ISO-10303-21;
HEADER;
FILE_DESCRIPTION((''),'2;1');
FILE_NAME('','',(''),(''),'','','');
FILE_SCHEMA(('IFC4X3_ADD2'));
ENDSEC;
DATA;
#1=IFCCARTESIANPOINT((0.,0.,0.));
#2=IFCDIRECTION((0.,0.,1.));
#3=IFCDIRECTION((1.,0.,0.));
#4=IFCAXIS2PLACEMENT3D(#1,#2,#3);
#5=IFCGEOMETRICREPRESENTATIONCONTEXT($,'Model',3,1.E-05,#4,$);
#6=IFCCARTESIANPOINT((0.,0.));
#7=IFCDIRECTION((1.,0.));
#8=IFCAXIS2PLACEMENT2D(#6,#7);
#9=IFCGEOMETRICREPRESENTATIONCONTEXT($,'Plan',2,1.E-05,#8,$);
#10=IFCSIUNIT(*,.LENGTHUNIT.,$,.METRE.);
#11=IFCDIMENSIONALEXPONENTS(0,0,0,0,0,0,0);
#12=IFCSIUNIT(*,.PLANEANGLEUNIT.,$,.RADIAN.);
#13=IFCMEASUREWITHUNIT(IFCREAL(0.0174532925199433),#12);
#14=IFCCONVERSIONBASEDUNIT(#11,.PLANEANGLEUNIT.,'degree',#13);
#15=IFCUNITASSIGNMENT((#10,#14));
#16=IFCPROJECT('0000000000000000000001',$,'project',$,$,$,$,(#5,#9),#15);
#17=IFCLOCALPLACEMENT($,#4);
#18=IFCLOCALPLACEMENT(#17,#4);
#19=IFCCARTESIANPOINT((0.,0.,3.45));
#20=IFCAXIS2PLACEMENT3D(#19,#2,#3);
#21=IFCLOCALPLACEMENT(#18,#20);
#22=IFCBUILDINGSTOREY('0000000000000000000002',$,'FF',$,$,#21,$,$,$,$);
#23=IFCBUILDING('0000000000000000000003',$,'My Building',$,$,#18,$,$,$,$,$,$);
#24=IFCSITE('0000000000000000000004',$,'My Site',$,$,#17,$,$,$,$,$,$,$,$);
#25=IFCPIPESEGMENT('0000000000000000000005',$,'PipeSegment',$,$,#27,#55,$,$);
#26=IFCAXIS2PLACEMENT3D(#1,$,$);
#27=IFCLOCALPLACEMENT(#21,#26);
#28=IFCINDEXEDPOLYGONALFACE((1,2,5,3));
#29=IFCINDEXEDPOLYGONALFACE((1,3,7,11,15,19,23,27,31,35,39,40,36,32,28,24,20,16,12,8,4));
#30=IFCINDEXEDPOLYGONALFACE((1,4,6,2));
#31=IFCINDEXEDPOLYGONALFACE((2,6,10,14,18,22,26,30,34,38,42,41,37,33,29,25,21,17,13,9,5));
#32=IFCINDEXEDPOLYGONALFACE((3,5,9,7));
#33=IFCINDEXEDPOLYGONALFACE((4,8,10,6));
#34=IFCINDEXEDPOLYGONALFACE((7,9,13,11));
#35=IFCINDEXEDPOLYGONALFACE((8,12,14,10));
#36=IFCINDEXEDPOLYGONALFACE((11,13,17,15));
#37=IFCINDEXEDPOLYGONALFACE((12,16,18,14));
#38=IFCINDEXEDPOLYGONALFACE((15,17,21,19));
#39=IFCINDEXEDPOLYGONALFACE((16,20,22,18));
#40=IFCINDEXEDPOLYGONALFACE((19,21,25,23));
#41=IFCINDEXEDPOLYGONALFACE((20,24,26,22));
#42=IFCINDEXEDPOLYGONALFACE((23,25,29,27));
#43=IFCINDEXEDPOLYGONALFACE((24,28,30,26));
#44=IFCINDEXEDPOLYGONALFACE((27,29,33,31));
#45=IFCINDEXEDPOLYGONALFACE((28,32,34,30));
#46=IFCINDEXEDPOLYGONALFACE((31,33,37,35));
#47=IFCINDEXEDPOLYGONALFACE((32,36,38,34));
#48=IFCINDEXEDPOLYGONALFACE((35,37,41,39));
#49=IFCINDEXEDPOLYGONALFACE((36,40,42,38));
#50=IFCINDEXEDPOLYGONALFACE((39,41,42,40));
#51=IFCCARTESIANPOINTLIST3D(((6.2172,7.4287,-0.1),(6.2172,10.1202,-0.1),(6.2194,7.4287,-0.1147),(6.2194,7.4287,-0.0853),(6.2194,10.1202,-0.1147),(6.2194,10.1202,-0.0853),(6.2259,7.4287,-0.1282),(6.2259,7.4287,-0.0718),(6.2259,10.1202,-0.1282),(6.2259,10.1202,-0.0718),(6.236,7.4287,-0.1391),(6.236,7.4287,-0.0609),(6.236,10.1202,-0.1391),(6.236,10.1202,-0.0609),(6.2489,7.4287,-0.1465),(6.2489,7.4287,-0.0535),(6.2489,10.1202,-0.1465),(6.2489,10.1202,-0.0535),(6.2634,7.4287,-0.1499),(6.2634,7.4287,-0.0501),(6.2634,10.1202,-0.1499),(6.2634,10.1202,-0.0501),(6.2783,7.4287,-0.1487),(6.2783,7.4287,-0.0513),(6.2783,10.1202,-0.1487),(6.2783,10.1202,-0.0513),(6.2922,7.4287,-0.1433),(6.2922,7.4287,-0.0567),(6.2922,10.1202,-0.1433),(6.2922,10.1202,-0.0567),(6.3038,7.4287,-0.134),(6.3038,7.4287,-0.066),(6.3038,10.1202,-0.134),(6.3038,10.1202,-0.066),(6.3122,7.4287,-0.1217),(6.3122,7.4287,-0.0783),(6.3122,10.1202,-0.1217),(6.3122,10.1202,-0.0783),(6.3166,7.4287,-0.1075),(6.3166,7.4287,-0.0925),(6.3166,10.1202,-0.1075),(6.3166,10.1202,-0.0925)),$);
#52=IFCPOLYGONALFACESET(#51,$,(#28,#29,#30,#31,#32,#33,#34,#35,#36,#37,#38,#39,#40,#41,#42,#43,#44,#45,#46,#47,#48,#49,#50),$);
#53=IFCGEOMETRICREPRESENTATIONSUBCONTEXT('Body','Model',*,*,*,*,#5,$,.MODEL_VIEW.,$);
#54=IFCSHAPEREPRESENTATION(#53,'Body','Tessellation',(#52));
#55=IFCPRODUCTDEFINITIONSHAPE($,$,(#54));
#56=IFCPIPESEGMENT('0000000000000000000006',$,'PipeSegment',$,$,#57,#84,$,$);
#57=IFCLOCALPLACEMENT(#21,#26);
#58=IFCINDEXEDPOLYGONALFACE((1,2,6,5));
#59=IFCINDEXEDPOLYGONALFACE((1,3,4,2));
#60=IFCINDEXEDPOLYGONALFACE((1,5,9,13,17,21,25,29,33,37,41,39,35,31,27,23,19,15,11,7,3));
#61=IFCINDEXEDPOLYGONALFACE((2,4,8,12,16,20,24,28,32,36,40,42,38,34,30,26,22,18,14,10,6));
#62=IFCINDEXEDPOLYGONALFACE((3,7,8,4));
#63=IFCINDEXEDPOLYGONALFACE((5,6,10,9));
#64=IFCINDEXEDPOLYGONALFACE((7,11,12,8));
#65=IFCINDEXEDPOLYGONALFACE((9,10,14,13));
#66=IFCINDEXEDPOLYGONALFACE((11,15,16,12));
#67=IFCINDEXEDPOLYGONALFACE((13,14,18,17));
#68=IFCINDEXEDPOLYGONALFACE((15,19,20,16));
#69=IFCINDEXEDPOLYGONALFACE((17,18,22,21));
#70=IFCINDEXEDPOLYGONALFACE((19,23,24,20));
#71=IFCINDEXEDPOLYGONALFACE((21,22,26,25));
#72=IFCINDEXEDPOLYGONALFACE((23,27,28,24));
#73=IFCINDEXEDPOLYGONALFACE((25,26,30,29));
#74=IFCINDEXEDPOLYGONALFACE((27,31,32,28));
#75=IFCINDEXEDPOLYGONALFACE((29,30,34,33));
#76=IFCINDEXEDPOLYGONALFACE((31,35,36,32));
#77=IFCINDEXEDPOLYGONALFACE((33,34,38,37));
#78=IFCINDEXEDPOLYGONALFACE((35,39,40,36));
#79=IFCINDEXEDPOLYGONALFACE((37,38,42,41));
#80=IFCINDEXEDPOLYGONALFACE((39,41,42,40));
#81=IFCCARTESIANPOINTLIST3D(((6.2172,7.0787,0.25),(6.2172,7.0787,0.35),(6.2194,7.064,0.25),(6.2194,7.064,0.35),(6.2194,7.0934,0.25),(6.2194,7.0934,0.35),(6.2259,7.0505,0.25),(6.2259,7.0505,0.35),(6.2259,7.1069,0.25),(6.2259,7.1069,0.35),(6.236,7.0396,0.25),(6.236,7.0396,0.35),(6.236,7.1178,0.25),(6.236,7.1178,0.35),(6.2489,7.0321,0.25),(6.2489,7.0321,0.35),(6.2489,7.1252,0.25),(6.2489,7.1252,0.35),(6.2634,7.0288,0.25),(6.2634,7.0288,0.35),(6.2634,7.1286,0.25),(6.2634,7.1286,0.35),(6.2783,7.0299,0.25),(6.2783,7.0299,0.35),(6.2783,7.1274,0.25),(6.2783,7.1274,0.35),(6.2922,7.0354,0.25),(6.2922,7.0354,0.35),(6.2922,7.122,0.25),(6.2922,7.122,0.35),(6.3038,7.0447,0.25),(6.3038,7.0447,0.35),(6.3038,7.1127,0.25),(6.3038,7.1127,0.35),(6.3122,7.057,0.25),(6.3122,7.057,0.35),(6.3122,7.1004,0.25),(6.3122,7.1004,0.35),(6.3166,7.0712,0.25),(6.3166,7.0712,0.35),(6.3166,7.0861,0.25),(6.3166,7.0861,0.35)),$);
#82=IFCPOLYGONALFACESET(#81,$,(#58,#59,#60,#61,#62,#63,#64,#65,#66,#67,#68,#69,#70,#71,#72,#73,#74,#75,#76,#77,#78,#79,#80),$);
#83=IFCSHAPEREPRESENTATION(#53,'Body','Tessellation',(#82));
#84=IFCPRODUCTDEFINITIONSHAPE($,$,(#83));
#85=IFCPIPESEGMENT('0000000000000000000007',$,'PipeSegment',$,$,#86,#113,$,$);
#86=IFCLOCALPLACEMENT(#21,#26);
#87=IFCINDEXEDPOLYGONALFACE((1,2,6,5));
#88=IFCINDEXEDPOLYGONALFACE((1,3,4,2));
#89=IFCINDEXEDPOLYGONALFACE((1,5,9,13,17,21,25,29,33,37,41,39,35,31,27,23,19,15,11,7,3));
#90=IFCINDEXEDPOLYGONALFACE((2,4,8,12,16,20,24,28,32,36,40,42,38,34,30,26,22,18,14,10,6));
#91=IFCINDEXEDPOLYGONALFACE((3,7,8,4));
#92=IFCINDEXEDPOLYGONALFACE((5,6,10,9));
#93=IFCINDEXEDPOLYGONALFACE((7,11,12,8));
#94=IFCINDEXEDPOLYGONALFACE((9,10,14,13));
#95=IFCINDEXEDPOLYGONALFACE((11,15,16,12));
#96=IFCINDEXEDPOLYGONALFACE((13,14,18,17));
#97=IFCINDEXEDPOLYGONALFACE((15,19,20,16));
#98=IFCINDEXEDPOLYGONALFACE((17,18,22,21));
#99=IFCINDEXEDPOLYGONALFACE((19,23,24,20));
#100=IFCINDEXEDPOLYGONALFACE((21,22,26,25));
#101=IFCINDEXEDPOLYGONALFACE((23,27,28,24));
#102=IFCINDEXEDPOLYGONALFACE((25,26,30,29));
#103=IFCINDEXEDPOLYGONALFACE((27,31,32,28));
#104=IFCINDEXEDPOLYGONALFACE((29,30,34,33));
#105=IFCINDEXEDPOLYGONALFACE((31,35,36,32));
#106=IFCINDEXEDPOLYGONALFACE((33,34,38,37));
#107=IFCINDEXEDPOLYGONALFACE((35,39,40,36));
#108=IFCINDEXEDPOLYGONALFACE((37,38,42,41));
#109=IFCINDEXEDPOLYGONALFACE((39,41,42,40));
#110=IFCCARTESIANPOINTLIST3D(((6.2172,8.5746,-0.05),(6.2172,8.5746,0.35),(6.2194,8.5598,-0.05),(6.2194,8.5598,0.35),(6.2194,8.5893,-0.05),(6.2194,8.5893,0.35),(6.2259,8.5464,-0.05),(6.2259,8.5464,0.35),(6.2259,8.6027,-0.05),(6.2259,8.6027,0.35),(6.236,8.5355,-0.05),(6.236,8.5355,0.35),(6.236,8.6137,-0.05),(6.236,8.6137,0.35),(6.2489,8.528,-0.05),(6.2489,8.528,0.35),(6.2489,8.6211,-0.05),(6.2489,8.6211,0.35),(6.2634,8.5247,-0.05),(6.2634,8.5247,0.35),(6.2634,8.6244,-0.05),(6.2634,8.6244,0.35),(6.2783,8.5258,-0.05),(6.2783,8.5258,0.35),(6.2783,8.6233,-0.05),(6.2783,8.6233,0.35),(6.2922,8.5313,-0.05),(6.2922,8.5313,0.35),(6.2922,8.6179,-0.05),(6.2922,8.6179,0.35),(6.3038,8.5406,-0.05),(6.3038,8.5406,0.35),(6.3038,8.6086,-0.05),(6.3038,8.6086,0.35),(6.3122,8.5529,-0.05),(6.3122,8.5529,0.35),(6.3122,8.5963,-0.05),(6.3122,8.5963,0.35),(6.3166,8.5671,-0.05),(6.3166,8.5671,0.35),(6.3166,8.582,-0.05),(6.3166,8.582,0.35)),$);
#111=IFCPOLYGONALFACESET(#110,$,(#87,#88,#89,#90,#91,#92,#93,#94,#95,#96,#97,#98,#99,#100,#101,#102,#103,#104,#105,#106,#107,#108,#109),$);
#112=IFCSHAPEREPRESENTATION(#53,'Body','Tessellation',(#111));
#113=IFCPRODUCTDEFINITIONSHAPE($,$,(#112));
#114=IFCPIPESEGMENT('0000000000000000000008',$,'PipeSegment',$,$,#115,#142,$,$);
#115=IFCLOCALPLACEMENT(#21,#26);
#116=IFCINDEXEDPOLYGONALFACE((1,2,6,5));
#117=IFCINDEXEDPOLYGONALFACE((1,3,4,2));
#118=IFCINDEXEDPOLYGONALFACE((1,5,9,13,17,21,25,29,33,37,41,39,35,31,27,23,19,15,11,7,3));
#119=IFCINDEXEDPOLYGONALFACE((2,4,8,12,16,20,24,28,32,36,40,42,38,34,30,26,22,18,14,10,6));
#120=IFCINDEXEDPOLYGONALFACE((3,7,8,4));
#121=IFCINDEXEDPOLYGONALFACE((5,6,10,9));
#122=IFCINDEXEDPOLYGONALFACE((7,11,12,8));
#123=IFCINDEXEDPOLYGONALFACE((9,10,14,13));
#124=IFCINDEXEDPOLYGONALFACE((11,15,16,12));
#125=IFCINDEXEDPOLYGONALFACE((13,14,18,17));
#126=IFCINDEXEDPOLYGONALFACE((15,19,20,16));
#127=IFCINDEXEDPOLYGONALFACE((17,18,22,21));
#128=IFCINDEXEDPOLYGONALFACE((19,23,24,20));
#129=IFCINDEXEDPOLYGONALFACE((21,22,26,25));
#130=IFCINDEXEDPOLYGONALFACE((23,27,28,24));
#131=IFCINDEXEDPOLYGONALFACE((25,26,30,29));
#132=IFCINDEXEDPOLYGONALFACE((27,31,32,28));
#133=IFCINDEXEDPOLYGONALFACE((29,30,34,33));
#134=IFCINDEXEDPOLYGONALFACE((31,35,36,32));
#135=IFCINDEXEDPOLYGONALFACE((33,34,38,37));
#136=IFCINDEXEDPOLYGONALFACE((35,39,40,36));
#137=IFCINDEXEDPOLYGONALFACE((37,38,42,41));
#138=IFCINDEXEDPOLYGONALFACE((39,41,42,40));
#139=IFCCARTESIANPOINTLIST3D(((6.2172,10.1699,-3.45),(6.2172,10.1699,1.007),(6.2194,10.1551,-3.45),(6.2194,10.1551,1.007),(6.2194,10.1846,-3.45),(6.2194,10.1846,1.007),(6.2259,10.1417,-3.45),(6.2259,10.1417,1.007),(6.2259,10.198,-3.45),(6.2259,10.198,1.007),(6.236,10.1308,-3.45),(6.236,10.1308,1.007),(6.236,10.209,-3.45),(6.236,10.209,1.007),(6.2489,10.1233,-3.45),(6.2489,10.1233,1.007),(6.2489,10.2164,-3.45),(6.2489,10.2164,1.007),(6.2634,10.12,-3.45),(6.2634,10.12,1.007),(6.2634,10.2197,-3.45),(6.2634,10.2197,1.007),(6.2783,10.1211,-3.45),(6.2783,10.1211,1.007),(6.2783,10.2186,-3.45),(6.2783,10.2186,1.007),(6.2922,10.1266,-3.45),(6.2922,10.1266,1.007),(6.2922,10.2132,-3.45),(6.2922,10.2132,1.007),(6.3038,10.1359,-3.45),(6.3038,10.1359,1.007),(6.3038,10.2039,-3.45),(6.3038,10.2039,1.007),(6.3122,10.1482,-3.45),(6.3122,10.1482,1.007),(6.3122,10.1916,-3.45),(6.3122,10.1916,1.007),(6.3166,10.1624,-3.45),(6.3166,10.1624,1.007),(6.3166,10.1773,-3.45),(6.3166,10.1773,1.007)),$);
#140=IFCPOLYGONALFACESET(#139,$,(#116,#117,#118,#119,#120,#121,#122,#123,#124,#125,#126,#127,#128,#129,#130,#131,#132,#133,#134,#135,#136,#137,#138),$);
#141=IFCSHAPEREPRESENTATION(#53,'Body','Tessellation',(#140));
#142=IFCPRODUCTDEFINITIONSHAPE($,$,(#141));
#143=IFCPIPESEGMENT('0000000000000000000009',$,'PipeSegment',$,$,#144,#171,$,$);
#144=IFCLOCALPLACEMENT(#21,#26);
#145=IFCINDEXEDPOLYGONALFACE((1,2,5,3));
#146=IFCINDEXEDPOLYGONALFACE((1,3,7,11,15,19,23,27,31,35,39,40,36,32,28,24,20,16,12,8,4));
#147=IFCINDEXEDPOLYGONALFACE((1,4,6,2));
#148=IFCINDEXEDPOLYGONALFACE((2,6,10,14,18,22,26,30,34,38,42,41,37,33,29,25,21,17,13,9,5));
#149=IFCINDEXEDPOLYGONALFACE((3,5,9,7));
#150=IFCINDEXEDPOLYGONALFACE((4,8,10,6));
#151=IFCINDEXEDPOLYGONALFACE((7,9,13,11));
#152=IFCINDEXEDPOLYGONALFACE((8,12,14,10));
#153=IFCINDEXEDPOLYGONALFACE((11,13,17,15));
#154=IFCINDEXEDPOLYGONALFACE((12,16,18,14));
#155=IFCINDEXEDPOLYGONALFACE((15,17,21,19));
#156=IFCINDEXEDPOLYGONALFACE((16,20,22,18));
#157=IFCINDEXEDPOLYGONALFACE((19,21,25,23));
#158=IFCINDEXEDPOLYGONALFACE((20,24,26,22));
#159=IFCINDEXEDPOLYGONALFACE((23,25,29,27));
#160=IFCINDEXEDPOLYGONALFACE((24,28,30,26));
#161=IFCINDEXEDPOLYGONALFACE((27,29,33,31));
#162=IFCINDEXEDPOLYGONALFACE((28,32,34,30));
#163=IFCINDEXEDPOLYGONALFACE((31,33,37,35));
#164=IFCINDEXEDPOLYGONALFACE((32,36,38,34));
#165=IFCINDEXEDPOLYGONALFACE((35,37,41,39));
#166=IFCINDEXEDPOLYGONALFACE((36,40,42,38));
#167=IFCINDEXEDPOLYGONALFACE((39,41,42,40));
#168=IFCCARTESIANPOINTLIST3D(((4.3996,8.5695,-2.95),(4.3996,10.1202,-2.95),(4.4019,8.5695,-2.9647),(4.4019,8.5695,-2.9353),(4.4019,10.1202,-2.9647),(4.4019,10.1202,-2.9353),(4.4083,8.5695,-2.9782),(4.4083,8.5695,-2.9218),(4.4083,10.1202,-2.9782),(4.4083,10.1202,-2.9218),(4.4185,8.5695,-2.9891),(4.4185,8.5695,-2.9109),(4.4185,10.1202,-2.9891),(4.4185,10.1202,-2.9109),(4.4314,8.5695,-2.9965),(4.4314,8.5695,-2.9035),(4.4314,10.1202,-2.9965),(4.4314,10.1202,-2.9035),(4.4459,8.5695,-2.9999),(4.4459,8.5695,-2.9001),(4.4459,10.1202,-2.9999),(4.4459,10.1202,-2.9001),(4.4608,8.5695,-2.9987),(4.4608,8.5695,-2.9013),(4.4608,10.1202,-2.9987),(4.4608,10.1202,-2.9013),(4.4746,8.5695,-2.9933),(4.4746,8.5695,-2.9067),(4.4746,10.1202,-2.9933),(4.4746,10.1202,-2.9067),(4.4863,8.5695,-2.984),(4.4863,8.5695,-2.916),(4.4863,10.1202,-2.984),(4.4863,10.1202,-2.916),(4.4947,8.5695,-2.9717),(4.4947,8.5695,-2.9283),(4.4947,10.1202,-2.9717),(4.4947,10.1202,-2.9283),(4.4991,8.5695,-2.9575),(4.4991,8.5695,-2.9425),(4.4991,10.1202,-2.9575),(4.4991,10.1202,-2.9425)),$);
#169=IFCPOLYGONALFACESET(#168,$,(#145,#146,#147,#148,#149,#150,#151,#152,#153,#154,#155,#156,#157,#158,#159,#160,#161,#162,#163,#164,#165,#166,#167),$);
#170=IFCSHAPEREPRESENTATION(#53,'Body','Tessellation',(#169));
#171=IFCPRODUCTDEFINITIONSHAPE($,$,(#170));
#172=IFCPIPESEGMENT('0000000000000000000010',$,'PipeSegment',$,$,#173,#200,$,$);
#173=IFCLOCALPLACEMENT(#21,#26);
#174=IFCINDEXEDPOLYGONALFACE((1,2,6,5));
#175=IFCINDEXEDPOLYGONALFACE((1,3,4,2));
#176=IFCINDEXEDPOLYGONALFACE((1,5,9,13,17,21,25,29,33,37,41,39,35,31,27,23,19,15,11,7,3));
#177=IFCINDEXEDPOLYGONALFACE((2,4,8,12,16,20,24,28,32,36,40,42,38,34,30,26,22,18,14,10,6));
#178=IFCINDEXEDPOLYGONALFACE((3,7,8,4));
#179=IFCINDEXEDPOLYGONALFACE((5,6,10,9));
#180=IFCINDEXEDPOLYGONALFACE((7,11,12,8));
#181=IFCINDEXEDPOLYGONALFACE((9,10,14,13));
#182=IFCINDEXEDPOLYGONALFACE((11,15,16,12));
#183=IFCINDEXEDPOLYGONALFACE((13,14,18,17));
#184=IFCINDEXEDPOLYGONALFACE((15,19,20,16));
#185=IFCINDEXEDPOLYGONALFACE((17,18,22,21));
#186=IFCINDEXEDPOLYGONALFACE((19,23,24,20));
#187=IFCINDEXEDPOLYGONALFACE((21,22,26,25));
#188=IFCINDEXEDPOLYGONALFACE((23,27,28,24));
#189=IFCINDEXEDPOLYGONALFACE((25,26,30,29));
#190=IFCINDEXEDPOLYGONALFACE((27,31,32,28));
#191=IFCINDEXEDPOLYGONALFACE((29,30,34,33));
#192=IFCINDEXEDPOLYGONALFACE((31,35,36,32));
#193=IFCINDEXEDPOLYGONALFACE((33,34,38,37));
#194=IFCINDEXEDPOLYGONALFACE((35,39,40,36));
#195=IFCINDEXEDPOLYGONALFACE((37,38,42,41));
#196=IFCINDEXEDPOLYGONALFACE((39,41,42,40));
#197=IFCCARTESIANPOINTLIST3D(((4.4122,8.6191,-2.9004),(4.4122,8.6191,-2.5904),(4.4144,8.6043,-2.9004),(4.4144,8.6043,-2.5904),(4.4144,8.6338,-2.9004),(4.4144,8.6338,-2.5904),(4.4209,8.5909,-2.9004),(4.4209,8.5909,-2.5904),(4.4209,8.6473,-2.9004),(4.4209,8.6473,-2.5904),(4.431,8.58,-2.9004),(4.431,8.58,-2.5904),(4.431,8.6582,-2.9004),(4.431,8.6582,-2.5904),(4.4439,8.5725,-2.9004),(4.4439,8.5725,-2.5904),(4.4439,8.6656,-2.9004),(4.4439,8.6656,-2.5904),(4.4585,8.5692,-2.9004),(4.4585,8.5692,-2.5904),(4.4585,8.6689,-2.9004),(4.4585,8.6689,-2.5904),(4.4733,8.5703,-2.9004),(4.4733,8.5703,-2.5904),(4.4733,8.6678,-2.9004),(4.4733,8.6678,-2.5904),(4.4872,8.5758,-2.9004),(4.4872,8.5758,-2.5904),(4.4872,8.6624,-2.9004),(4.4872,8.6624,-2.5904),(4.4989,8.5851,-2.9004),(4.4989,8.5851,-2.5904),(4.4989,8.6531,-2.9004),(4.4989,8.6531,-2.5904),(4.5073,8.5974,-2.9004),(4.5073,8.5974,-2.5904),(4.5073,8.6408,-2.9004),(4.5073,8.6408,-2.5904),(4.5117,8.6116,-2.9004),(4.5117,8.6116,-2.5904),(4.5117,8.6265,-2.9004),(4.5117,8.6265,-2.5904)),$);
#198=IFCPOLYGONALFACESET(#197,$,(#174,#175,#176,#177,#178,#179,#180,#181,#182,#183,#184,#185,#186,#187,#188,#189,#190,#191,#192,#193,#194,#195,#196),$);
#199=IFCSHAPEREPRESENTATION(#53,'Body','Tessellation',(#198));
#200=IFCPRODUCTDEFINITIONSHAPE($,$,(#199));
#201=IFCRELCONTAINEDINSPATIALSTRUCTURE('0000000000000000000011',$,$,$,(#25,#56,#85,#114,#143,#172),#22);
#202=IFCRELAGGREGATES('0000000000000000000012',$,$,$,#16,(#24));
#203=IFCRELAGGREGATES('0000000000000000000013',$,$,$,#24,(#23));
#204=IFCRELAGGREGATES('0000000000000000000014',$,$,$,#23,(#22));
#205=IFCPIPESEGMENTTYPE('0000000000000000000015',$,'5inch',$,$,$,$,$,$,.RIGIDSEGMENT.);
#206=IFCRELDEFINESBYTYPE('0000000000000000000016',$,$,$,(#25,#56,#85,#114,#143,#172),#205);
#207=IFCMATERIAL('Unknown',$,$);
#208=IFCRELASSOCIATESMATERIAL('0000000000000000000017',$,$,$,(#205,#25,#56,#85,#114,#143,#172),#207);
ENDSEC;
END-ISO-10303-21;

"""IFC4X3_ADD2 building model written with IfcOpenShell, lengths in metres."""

from ifc_helpers import new_model, entity, si_unit, converted_unit, frame, origin_with_axes, origin_2d_with_axis, place, context, subcontext, project, spatial, circle, extrude, material, material_profile, profile_set, profile_usage, type_object, element, save


model = new_model("IFC4X3_ADD2")

# Units and contexts
model_context = context("Model", 3, precision=1e-05, world=origin_with_axes())
plan_context = context("Plan", 2, precision=1e-05, world=origin_2d_with_axis())
body_context = subcontext(model_context, "Body", "Model", "MODEL_VIEW")
ifc_project = project(units=[si_unit("LENGTHUNIT", "METRE"), converted_unit("PLANEANGLEUNIT", "degree", entity("IfcReal", 0.0174532925199433), si_unit("PLANEANGLEUNIT", "RADIAN"), dimensions=[0, 0, 0, 0, 0, 0, 0])], contexts=[model_context, plan_context])

# Site, building, storey
site_placement = place(None, origin_with_axes())
site = spatial("IfcSite", under=ifc_project, at=site_placement, Name="My Site")
building_placement = place(site_placement, origin_with_axes())
building = spatial("IfcBuilding", under=site, at=building_placement, Name="My Building")
storey_placement = place(building_placement, frame((0.0, 0.0, 3.45), z_axis=(0.0, 0.0, 1.0), x_axis=(1.0, 0.0, 0.0)))
storey = spatial("IfcBuildingStorey", under=building, at=storey_placement, Name="FF")

# Shared definitions
ifc_material_1 = material(Name="Unknown")

# Pipe segments
ifc_material_profile_1 = material_profile(ifc_material_1, circle(Radius=0.05))
ifc_profile_set_1 = profile_set([ifc_material_profile_1])
ifc_profile_usage_1 = profile_usage(ifc_profile_set_1, cardinal=5)
pipe_segment_type_1 = type_object("IfcPipeSegmentType", Name="5inch", PredefinedType="RIGIDSEGMENT", material=ifc_profile_set_1)
pipe_segment_1_placement = place(storey_placement, frame((6.2672, 7.4287, -0.1), z_axis=(0.0, 1.0, 0.0), x_axis=(-1.0, 0.0, 0.0)))
element("IfcPipeSegment", 1, at=pipe_segment_1_placement, inside=storey, type_object=pipe_segment_type_1, material=ifc_profile_usage_1, Name="PipeSegment", context=body_context, shape_type="SweptSolid", body=[
    extrude(circle(Radius=0.05), origin_with_axes(), (0.0, 0.0, 1.0), 2.6915),
])
ifc_profile_usage_2 = profile_usage(ifc_profile_set_1, cardinal=5)
pipe_segment_2_placement = place(storey_placement, frame((6.2672, 7.0787, 0.25), z_axis=(0.0, 0.0, 1.0), x_axis=(-1.0, 0.0, 0.0)))
element("IfcPipeSegment", 2, at=pipe_segment_2_placement, inside=storey, type_object=pipe_segment_type_1, material=ifc_profile_usage_2, Name="PipeSegment", context=body_context, shape_type="SweptSolid", body=[
    extrude(circle(Radius=0.05), origin_with_axes(), (0.0, 0.0, 1.0), 0.1),
])
ifc_profile_usage_3 = profile_usage(ifc_profile_set_1, cardinal=5)
pipe_segment_3_placement = place(storey_placement, frame((6.2672, 8.5746, -0.05), z_axis=(0.0, 0.0, 1.0), x_axis=(-1.0, 0.0, 0.0)))
element("IfcPipeSegment", 3, at=pipe_segment_3_placement, inside=storey, type_object=pipe_segment_type_1, material=ifc_profile_usage_3, Name="PipeSegment", context=body_context, shape_type="SweptSolid", body=[
    extrude(circle(Radius=0.05), origin_with_axes(), (0.0, 0.0, 1.0), 0.4),
])
ifc_profile_usage_4 = profile_usage(ifc_profile_set_1, cardinal=5)
pipe_segment_4_placement = place(storey_placement, frame((6.2672, 10.1699, -3.45), z_axis=(0.0, 0.0, 1.0), x_axis=(-1.0, 0.0, 0.0)))
element("IfcPipeSegment", 4, at=pipe_segment_4_placement, inside=storey, type_object=pipe_segment_type_1, material=ifc_profile_usage_4, Name="PipeSegment", context=body_context, shape_type="SweptSolid", body=[
    extrude(circle(Radius=0.05), origin_with_axes(), (0.0, 0.0, 1.0), 4.457),
])
ifc_profile_usage_5 = profile_usage(ifc_profile_set_1, cardinal=5)
pipe_segment_5_placement = place(storey_placement, frame((4.4496, 8.5695, -2.95), z_axis=(0.0, 1.0, 0.0), x_axis=(-1.0, 0.0, 0.0)))
element("IfcPipeSegment", 5, at=pipe_segment_5_placement, inside=storey, type_object=pipe_segment_type_1, material=ifc_profile_usage_5, Name="PipeSegment", context=body_context, shape_type="SweptSolid", body=[
    extrude(circle(Radius=0.05), origin_with_axes(), (0.0, 0.0, 1.0), 1.5508),
])
ifc_profile_usage_6 = profile_usage(ifc_profile_set_1, cardinal=5)
pipe_segment_6_placement = place(storey_placement, frame((4.4622, 8.6191, -2.9004), z_axis=(0.0, 0.0, 1.0), x_axis=(-1.0, 0.0, 0.0)))
element("IfcPipeSegment", 6, at=pipe_segment_6_placement, inside=storey, type_object=pipe_segment_type_1, material=ifc_profile_usage_6, Name="PipeSegment", context=body_context, shape_type="SweptSolid", body=[
    extrude(circle(Radius=0.05), origin_with_axes(), (0.0, 0.0, 1.0), 0.3099),
])

save(model, "model.ifc")
